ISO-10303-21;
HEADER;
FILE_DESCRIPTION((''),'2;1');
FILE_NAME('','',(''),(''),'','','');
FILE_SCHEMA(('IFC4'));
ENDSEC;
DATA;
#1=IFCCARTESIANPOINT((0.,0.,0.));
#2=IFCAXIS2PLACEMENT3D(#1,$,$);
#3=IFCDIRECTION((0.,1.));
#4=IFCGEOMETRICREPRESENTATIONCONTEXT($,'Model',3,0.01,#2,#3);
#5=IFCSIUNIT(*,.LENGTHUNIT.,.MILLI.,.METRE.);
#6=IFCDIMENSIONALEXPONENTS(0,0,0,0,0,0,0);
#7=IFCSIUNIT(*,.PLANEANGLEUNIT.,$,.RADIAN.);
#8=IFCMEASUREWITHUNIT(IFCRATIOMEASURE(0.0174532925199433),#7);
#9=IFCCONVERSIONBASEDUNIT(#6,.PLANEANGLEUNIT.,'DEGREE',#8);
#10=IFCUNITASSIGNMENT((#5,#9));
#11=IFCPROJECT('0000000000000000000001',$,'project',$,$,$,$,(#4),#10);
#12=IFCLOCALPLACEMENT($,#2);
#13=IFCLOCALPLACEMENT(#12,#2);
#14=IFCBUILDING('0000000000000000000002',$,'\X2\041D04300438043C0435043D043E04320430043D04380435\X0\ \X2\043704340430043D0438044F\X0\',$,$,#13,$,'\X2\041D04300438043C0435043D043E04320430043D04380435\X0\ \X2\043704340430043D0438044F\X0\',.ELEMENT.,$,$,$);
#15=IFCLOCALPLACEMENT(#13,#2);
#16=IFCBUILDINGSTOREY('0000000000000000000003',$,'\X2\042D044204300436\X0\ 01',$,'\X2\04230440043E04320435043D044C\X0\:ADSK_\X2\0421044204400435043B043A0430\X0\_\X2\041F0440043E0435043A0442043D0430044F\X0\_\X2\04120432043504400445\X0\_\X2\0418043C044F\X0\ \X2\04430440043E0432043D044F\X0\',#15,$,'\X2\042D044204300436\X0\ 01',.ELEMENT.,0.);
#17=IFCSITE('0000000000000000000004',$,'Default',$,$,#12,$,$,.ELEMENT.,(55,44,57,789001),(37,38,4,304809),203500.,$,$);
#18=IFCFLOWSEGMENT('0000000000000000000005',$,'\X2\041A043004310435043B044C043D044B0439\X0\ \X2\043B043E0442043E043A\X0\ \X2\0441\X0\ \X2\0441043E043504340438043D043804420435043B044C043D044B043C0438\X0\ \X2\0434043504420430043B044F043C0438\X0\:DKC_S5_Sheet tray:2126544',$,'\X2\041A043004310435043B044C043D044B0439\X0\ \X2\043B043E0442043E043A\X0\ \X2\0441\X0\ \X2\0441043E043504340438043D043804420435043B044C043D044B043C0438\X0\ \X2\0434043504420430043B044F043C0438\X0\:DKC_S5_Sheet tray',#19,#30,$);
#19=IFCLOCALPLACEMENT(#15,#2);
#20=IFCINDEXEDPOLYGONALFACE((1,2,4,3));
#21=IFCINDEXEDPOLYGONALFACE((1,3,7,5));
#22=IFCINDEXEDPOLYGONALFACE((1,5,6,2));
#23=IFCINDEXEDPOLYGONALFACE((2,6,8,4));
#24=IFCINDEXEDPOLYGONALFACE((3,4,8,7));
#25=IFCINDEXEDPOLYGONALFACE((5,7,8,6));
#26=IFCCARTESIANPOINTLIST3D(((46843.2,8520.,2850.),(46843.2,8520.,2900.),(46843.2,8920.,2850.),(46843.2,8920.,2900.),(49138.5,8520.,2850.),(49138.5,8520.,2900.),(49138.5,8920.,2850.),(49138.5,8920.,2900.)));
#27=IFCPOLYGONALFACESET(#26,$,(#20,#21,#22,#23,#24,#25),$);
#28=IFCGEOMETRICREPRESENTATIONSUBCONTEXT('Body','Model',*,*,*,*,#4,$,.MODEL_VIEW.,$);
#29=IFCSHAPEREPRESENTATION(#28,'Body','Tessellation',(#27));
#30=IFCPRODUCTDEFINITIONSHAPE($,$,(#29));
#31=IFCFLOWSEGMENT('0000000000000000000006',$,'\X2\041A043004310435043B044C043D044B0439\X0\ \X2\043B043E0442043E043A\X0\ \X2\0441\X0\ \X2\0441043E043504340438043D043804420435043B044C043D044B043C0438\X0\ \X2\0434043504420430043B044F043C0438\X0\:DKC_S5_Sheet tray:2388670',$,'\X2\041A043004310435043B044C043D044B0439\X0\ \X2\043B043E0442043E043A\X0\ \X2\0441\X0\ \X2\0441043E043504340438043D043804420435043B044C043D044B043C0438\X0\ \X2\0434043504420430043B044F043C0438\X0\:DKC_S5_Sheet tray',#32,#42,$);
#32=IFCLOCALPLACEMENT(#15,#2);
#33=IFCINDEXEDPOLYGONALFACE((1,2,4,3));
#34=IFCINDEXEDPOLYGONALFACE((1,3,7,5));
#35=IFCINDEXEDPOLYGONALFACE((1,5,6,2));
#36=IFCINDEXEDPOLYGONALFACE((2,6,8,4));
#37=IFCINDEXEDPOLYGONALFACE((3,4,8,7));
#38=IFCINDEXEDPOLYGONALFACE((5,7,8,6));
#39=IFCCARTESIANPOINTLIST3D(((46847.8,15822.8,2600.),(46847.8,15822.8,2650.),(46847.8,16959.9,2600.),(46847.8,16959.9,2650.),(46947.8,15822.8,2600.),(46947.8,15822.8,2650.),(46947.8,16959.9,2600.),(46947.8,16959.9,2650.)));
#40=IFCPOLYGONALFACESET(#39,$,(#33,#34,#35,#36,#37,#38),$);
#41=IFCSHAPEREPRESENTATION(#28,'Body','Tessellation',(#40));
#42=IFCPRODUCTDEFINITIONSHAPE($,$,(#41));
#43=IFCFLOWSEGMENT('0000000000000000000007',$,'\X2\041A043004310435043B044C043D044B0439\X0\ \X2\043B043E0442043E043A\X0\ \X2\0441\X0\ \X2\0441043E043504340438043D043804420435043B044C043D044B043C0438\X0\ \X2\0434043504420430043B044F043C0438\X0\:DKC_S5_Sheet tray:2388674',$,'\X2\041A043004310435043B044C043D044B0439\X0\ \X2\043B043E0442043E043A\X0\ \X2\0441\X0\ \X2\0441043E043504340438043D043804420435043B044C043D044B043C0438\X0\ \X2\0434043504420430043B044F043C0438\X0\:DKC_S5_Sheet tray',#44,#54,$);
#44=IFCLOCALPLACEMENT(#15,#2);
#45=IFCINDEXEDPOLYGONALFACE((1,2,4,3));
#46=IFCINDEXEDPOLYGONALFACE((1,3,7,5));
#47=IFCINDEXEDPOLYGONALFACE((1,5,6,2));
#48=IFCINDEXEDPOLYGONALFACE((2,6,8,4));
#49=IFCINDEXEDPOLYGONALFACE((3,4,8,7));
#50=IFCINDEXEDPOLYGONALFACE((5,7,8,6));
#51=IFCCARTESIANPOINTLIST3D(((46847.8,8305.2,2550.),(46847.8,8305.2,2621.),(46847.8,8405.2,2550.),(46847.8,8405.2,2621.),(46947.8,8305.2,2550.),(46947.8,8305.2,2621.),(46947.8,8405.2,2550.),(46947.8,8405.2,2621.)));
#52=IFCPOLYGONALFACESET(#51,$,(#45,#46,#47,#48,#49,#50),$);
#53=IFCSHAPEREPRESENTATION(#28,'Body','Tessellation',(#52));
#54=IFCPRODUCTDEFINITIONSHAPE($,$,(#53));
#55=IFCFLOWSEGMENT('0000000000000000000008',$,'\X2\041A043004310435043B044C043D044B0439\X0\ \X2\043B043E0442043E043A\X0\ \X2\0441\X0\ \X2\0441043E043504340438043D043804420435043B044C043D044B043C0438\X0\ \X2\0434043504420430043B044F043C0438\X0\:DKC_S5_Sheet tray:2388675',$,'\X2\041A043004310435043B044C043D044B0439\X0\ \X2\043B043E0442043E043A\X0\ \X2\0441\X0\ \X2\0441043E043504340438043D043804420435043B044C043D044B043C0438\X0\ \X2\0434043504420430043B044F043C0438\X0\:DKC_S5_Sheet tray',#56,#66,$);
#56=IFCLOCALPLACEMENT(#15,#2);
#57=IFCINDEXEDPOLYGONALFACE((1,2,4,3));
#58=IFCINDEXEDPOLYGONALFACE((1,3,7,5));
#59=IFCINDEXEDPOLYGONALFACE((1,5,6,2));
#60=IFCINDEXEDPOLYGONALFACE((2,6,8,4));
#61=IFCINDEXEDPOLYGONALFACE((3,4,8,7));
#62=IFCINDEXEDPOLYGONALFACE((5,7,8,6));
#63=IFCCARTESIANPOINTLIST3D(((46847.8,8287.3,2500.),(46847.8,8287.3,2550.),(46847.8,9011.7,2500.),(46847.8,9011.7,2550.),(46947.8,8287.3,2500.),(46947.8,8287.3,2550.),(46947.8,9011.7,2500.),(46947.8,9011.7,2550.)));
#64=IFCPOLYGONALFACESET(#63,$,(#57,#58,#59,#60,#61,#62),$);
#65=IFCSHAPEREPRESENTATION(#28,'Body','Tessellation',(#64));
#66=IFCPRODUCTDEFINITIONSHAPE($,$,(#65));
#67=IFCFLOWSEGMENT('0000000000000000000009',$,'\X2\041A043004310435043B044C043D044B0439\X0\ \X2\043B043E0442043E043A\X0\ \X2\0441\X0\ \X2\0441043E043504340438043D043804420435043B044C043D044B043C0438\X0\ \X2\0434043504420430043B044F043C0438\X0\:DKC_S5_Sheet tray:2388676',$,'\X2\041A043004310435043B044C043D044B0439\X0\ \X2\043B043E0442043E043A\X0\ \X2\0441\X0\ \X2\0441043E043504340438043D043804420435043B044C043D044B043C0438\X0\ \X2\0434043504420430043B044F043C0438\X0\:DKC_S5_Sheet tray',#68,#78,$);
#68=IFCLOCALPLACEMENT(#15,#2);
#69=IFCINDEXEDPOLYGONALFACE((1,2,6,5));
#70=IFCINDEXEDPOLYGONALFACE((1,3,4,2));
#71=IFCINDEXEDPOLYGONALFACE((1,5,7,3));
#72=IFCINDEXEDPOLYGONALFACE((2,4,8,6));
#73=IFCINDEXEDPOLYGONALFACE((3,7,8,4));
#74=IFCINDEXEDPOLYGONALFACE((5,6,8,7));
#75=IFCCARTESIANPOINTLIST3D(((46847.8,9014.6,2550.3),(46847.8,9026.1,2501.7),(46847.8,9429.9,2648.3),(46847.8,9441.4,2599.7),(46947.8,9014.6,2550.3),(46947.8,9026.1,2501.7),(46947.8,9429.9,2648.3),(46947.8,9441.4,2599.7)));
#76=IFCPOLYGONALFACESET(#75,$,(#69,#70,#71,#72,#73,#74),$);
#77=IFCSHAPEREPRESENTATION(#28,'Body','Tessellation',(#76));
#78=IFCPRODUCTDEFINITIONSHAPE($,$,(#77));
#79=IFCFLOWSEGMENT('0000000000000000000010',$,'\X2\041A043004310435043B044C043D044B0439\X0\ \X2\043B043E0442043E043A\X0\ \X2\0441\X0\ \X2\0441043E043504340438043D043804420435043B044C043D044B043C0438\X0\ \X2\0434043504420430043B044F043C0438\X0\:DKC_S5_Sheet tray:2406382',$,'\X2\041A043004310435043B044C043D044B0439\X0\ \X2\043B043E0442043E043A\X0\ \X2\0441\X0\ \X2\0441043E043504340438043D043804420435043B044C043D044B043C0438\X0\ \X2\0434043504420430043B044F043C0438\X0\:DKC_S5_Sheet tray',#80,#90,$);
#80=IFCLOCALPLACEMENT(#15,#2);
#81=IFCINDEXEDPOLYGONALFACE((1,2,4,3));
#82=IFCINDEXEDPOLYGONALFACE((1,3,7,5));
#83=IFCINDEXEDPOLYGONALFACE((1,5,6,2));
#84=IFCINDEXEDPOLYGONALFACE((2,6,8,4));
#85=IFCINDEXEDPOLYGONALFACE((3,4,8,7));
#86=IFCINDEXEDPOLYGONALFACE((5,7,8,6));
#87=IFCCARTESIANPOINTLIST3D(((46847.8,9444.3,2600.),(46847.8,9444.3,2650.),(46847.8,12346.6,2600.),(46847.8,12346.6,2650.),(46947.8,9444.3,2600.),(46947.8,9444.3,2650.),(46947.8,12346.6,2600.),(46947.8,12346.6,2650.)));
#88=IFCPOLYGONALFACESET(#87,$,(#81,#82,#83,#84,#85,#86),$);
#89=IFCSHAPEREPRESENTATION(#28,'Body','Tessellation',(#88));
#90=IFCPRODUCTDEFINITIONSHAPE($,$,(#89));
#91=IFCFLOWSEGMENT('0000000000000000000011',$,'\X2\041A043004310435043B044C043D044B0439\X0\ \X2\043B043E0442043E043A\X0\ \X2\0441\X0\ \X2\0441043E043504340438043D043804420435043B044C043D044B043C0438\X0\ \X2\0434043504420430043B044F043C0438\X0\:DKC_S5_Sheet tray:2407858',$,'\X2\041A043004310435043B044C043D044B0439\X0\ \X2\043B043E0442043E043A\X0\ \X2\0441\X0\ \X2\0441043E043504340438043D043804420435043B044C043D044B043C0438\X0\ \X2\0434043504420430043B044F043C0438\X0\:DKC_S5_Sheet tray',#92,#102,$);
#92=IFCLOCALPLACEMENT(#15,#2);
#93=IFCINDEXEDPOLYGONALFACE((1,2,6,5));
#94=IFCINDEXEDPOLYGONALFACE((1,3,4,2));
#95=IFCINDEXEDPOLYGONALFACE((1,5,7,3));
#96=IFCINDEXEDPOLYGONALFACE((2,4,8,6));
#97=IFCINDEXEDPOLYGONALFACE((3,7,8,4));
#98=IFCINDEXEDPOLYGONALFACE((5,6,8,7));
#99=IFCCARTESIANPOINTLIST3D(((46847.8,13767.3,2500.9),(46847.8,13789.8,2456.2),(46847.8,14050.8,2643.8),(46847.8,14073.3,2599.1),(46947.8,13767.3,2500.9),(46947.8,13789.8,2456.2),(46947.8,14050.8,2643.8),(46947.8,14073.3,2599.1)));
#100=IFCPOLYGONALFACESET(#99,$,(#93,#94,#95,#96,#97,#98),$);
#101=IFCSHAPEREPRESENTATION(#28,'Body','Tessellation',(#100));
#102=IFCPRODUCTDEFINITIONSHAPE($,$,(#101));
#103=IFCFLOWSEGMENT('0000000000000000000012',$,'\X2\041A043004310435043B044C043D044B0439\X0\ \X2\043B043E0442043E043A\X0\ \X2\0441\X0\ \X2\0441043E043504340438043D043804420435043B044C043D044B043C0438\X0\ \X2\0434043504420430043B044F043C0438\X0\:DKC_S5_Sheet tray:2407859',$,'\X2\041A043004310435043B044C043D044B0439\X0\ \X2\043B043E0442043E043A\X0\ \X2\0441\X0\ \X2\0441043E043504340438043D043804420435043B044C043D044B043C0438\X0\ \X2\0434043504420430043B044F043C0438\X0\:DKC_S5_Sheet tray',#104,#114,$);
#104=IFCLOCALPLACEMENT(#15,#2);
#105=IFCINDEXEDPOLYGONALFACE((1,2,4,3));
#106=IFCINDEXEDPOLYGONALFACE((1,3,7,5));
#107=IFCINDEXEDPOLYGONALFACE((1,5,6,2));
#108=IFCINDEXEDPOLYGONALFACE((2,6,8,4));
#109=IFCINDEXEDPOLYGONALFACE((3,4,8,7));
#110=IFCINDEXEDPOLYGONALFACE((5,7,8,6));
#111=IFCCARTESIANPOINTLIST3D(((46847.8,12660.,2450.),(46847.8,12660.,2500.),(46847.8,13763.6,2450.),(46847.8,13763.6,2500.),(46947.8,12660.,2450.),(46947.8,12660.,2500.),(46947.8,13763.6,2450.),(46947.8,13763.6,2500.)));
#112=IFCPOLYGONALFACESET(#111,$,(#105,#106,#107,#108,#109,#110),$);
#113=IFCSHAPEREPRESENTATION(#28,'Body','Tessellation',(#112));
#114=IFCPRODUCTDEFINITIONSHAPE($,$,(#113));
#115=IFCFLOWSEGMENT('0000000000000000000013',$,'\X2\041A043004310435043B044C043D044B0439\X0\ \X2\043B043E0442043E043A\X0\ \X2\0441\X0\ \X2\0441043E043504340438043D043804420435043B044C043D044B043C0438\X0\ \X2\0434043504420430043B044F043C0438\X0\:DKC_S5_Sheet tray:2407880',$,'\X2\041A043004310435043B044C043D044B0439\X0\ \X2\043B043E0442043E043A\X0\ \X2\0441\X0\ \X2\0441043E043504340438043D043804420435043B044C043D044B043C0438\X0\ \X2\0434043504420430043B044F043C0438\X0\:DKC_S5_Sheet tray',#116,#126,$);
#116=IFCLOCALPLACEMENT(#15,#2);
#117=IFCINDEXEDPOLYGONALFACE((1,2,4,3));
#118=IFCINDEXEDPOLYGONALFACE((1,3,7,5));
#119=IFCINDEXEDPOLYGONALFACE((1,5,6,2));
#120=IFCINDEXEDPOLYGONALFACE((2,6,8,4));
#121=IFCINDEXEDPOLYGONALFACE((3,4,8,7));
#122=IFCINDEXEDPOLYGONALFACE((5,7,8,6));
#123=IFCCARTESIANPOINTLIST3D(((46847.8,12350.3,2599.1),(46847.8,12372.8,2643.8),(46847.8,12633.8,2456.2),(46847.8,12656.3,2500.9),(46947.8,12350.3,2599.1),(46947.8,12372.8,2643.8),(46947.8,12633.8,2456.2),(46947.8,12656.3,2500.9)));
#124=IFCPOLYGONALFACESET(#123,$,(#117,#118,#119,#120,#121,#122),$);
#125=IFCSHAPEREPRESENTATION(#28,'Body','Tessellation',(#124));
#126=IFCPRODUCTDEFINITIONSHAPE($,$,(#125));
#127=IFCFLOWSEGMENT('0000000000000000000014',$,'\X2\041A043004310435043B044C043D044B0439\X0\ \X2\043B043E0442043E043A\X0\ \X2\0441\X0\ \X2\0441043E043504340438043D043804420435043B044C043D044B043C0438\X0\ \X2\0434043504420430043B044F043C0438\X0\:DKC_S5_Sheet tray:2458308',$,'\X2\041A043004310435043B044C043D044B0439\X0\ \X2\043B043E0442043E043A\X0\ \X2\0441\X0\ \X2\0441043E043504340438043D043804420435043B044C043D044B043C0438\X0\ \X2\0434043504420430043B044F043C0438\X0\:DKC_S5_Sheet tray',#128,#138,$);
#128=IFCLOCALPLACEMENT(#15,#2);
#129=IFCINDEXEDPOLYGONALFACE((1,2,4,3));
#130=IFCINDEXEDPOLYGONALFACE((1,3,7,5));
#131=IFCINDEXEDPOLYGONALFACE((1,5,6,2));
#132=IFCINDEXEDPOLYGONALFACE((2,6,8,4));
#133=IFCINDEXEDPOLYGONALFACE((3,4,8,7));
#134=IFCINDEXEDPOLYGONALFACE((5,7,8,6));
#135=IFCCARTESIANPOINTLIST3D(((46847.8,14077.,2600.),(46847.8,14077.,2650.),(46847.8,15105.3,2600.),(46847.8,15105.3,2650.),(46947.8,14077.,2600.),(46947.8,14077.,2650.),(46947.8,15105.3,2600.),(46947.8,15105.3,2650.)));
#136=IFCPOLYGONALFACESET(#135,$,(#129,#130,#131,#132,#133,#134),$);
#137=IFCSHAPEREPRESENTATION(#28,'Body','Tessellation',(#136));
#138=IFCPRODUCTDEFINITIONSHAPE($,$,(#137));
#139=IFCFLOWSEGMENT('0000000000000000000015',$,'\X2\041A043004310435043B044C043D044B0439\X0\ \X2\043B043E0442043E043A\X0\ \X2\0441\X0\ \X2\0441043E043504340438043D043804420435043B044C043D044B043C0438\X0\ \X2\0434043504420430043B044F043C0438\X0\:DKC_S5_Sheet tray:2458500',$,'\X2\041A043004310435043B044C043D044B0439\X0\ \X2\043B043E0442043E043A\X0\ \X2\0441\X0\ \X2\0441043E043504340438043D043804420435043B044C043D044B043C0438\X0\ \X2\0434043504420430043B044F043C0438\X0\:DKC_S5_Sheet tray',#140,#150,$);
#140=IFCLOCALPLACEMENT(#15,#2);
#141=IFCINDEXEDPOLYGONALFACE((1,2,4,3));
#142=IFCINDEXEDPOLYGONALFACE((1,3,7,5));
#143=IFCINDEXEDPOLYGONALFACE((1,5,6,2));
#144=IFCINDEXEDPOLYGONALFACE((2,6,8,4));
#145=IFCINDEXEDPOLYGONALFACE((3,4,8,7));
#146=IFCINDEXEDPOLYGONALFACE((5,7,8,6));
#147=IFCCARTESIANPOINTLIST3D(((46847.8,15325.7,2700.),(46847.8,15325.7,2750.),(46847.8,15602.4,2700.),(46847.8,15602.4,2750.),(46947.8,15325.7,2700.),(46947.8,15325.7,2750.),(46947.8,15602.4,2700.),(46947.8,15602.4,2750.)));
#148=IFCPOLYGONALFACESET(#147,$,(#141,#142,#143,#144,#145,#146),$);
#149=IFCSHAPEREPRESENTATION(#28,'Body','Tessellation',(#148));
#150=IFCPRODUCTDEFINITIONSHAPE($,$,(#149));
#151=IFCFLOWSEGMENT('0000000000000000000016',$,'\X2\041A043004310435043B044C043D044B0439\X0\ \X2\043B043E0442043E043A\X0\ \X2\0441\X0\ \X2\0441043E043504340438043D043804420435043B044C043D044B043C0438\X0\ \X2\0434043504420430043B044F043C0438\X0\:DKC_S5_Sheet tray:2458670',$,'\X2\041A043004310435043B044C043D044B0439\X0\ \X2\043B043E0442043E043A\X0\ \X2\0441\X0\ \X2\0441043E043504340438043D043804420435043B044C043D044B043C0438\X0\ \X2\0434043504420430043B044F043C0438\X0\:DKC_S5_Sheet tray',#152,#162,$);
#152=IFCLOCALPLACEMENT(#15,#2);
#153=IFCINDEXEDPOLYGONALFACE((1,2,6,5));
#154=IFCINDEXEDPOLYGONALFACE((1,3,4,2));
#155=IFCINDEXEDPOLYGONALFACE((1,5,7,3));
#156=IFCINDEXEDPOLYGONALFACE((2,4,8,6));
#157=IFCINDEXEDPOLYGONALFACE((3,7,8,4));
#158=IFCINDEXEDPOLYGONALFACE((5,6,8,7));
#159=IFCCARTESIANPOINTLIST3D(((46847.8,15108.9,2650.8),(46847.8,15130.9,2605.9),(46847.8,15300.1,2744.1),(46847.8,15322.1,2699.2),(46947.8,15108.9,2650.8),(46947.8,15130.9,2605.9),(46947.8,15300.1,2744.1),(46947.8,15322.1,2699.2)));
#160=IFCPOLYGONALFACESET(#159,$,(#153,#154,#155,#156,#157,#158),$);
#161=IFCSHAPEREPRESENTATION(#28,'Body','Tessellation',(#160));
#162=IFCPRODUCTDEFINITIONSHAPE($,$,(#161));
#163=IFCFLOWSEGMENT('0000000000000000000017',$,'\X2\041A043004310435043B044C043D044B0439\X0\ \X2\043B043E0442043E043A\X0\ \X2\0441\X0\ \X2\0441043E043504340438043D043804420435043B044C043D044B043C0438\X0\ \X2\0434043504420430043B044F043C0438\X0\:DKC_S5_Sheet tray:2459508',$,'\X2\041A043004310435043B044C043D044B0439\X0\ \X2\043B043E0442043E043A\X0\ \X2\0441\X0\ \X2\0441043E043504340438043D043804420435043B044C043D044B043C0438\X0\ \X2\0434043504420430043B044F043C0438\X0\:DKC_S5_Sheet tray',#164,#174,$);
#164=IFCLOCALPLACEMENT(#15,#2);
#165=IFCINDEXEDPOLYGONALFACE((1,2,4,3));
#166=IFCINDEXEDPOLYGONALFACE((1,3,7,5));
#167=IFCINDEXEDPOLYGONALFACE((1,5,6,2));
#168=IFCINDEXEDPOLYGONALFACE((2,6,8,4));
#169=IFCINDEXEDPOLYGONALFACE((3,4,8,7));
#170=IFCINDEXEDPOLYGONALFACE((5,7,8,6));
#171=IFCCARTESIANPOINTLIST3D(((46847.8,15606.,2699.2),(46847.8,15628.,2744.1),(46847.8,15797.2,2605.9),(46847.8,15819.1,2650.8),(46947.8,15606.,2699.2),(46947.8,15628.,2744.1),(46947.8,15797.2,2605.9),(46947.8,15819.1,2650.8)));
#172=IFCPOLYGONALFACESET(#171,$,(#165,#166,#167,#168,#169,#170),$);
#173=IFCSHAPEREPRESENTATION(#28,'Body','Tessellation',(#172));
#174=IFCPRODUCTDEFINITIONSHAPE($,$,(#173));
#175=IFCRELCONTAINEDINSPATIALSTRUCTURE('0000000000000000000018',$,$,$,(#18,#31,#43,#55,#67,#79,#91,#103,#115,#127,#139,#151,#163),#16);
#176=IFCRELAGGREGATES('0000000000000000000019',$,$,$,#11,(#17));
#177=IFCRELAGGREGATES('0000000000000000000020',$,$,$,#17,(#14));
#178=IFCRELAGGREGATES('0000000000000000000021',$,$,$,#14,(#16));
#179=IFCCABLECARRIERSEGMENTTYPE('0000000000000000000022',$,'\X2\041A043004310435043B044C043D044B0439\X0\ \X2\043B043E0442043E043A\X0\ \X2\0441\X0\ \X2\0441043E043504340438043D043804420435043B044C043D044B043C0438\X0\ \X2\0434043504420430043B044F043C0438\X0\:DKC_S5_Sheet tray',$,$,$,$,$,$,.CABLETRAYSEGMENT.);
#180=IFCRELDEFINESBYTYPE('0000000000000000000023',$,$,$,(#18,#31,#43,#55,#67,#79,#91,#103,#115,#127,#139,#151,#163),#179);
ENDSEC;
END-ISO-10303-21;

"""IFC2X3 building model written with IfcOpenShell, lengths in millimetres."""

from ifc_helpers import new_model, entity, si_unit, converted_unit, direction, frame, frame_2d, origin, origin_2d_with_axis, place, context, subcontext, project, spatial, rectangle, extrude, type_object, element, save


model = new_model("IFC2X3")

# Units and contexts
model_context = context("Model", 3, precision=0.01, world=origin(), true_north=direction((0.0, 1.0)))
body_context = subcontext(model_context, "Body", "Model", "MODEL_VIEW")
ifc_project = project(units=[si_unit("LENGTHUNIT", "METRE", prefix="MILLI"), converted_unit("PLANEANGLEUNIT", "DEGREE", entity("IfcRatioMeasure", 0.0174532925199433), si_unit("PLANEANGLEUNIT", "RADIAN"), dimensions=[0, 0, 0, 0, 0, 0, 0])], contexts=[model_context])

# Site, building, storey
site_placement = place(None, origin())
site = spatial("IfcSite", under=ifc_project, at=site_placement, Name="Default", CompositionType="ELEMENT", RefLatitude=(55, 44, 57, 789001), RefLongitude=(37, 38, 4, 304809), RefElevation=203500.0)
building_placement = place(site_placement, origin())
building = spatial("IfcBuilding", under=site, at=building_placement, Name="Наименование здания", LongName="Наименование здания", CompositionType="ELEMENT")
storey_placement = place(building_placement, origin())
storey = spatial("IfcBuildingStorey", under=building, at=storey_placement, Name="Этаж 01", ObjectType="Уровень:ADSK_Стрелка_Проектная_Вверх_Имя уровня", LongName="Этаж 01", CompositionType="ELEMENT", Elevation=0.0)

# Flow segments
cable_carrier_segment_type = type_object("IfcCableCarrierSegmentType", Name="Кабельный лоток с соединительными деталями:DKC_S5_Sheet tray", PredefinedType="CABLETRAYSEGMENT")
flow_segment_1_placement = place(storey_placement, frame((46843.2, 8520.0, 2850.0)))
element("IfcFlowSegment", 1, at=flow_segment_1_placement, inside=storey, type_object=cable_carrier_segment_type, Name="Кабельный лоток с соединительными деталями:DKC_S5_Sheet tray:2126544", ObjectType="Кабельный лоток с соединительными деталями:DKC_S5_Sheet tray", context=body_context, shape_type="SweptSolid", body=[
    extrude(rectangle(XDim=2295.4, YDim=400.0, at=origin_2d_with_axis()), frame((1147.7, 200.0, 0.0)), (0.0, 0.0, 1.0), 50.0),
])
flow_segment_2_placement = place(storey_placement, frame((46847.8, 15822.8, 2600.0)))
element("IfcFlowSegment", 2, at=flow_segment_2_placement, inside=storey, type_object=cable_carrier_segment_type, Name="Кабельный лоток с соединительными деталями:DKC_S5_Sheet tray:2388670", ObjectType="Кабельный лоток с соединительными деталями:DKC_S5_Sheet tray", context=body_context, shape_type="SweptSolid", body=[
    extrude(rectangle(XDim=1137.1, YDim=100.0, at=origin_2d_with_axis()), frame((50.0, 568.5, 0.0), z_axis=(0.0, 0.0, 1.0), x_axis=(0.0, 1.0, 0.0)), (0.0, 0.0, 1.0), 50.0),
])
flow_segment_3_placement = place(storey_placement, frame((46847.8, 8305.2, 2550.0)))
element("IfcFlowSegment", 3, at=flow_segment_3_placement, inside=storey, type_object=cable_carrier_segment_type, Name="Кабельный лоток с соединительными деталями:DKC_S5_Sheet tray:2388674", ObjectType="Кабельный лоток с соединительными деталями:DKC_S5_Sheet tray", context=body_context, shape_type="SweptSolid", body=[
    extrude(rectangle(XDim=100.0, YDim=100.0, at=origin_2d_with_axis()), frame((50.0, 50.0, 0.0), z_axis=(0.0, 0.0, 1.0), x_axis=(-1.0, 0.0, 0.0)), (0.0, 0.0, 1.0), 71.0),
])
flow_segment_4_placement = place(storey_placement, frame((46847.8, 8287.3, 2500.0)))
element("IfcFlowSegment", 4, at=flow_segment_4_placement, inside=storey, type_object=cable_carrier_segment_type, Name="Кабельный лоток с соединительными деталями:DKC_S5_Sheet tray:2388675", ObjectType="Кабельный лоток с соединительными деталями:DKC_S5_Sheet tray", context=body_context, shape_type="SweptSolid", body=[
    extrude(rectangle(XDim=724.4, YDim=100.0, at=origin_2d_with_axis()), frame((50.0, 362.2, 0.0), z_axis=(0.0, 0.0, 1.0), x_axis=(0.0, -1.0, 0.0)), (0.0, 0.0, 1.0), 50.0),
])
flow_segment_5_placement = place(storey_placement, frame((46847.8, 9014.6, 2501.7)))
element("IfcFlowSegment", 5, at=flow_segment_5_placement, inside=storey, type_object=cable_carrier_segment_type, Name="Кабельный лоток с соединительными деталями:DKC_S5_Sheet tray:2388676", ObjectType="Кабельный лоток с соединительными деталями:DKC_S5_Sheet tray", context=body_context, shape_type="SweptSolid", body=[
    extrude(rectangle(XDim=50.0, YDim=426.7, at=frame_2d((0.0, 0.0), x_axis=(0.0, 1.0))), frame((0.0, 213.4, 73.3), z_axis=(1.0, 0.0, 0.0), x_axis=(0.0, -0.973269, -0.22967)), (0.0, 0.0, 1.0), 100.0),
])
flow_segment_6_placement = place(storey_placement, frame((46847.8, 9444.3, 2600.0)))
element("IfcFlowSegment", 6, at=flow_segment_6_placement, inside=storey, type_object=cable_carrier_segment_type, Name="Кабельный лоток с соединительными деталями:DKC_S5_Sheet tray:2406382", ObjectType="Кабельный лоток с соединительными деталями:DKC_S5_Sheet tray", context=body_context, shape_type="SweptSolid", body=[
    extrude(rectangle(XDim=2902.3, YDim=100.0, at=origin_2d_with_axis()), frame((50.0, 1451.2, 0.0), z_axis=(0.0, 0.0, 1.0), x_axis=(0.0, 1.0, 0.0)), (0.0, 0.0, 1.0), 50.0),
])
flow_segment_7_placement = place(storey_placement, frame((46847.8, 13767.3, 2456.2)))
element("IfcFlowSegment", 7, at=flow_segment_7_placement, inside=storey, type_object=cable_carrier_segment_type, Name="Кабельный лоток с соединительными деталями:DKC_S5_Sheet tray:2407858", ObjectType="Кабельный лоток с соединительными деталями:DKC_S5_Sheet tray", context=body_context, shape_type="SweptSolid", body=[
    extrude(rectangle(XDim=50.0, YDim=317.5, at=frame_2d((0.0, 0.0), x_axis=(0.0, 1.0))), frame((0.0, 153.0, 93.8), z_axis=(1.0, 0.0, 0.0), x_axis=(0.0, -0.892981, -0.450095)), (0.0, 0.0, 1.0), 100.0),
])
flow_segment_8_placement = place(storey_placement, frame((46847.8, 12660.0, 2450.0)))
element("IfcFlowSegment", 8, at=flow_segment_8_placement, inside=storey, type_object=cable_carrier_segment_type, Name="Кабельный лоток с соединительными деталями:DKC_S5_Sheet tray:2407859", ObjectType="Кабельный лоток с соединительными деталями:DKC_S5_Sheet tray", context=body_context, shape_type="SweptSolid", body=[
    extrude(rectangle(XDim=1103.6, YDim=100.0, at=origin_2d_with_axis()), frame((50.0, 551.8, 0.0), z_axis=(0.0, 0.0, 1.0), x_axis=(0.0, -1.0, 0.0)), (0.0, 0.0, 1.0), 50.0),
])
flow_segment_9_placement = place(storey_placement, frame((46847.8, 12350.3, 2456.2)))
element("IfcFlowSegment", 9, at=flow_segment_9_placement, inside=storey, type_object=cable_carrier_segment_type, Name="Кабельный лоток с соединительными деталями:DKC_S5_Sheet tray:2407880", ObjectType="Кабельный лоток с соединительными деталями:DKC_S5_Sheet tray", context=body_context, shape_type="SweptSolid", body=[
    extrude(rectangle(XDim=50.0, YDim=317.5, at=frame_2d((0.0, 0.0), x_axis=(0.0, 1.0))), frame((0.0, 153.0, 93.8), z_axis=(1.0, 0.0, 0.0), x_axis=(0.0, 0.892981, -0.450095)), (0.0, 0.0, 1.0), 100.0),
])
flow_segment_10_placement = place(storey_placement, frame((46847.8, 14077.0, 2600.0)))
element("IfcFlowSegment", 10, at=flow_segment_10_placement, inside=storey, type_object=cable_carrier_segment_type, Name="Кабельный лоток с соединительными деталями:DKC_S5_Sheet tray:2458308", ObjectType="Кабельный лоток с соединительными деталями:DKC_S5_Sheet tray", context=body_context, shape_type="SweptSolid", body=[
    extrude(rectangle(XDim=1028.3, YDim=100.0, at=origin_2d_with_axis()), frame((50.0, 514.1, 0.0), z_axis=(0.0, 0.0, 1.0), x_axis=(0.0, 1.0, 0.0)), (0.0, 0.0, 1.0), 50.0),
])
flow_segment_11_placement = place(storey_placement, frame((46847.8, 15325.7, 2700.0)))
element("IfcFlowSegment", 11, at=flow_segment_11_placement, inside=storey, type_object=cable_carrier_segment_type, Name="Кабельный лоток с соединительными деталями:DKC_S5_Sheet tray:2458500", ObjectType="Кабельный лоток с соединительными деталями:DKC_S5_Sheet tray", context=body_context, shape_type="SweptSolid", body=[
    extrude(rectangle(XDim=276.7, YDim=100.0, at=origin_2d_with_axis()), frame((50.0, 138.3, 0.0), z_axis=(0.0, 0.0, 1.0), x_axis=(0.0, 1.0, 0.0)), (0.0, 0.0, 1.0), 50.0),
])
flow_segment_12_placement = place(storey_placement, frame((46847.8, 15108.9, 2605.9)))
element("IfcFlowSegment", 12, at=flow_segment_12_placement, inside=storey, type_object=cable_carrier_segment_type, Name="Кабельный лоток с соединительными деталями:DKC_S5_Sheet tray:2458670", ObjectType="Кабельный лоток с соединительными деталями:DKC_S5_Sheet tray", context=body_context, shape_type="SweptSolid", body=[
    extrude(rectangle(XDim=50.0, YDim=212.7, at=frame_2d((0.0, 0.0), x_axis=(0.0, 1.0))), frame((0.0, 106.6, 69.1), z_axis=(1.0, 0.0, 0.0), x_axis=(0.0, -0.898794, -0.438371)), (0.0, 0.0, 1.0), 100.0),
])
flow_segment_13_placement = place(storey_placement, frame((46847.8, 15606.0, 2605.9)))
element("IfcFlowSegment", 13, at=flow_segment_13_placement, inside=storey, type_object=cable_carrier_segment_type, Name="Кабельный лоток с соединительными деталями:DKC_S5_Sheet tray:2459508", ObjectType="Кабельный лоток с соединительными деталями:DKC_S5_Sheet tray", context=body_context, shape_type="SweptSolid", body=[
    extrude(rectangle(XDim=50.0, YDim=212.7, at=frame_2d((0.0, 0.0), x_axis=(0.0, 1.0))), frame((0.0, 106.6, 69.1), z_axis=(1.0, 0.0, 0.0), x_axis=(0.0, 0.898794, -0.438371)), (0.0, 0.0, 1.0), 100.0),
])

save(model, "model.ifc")
